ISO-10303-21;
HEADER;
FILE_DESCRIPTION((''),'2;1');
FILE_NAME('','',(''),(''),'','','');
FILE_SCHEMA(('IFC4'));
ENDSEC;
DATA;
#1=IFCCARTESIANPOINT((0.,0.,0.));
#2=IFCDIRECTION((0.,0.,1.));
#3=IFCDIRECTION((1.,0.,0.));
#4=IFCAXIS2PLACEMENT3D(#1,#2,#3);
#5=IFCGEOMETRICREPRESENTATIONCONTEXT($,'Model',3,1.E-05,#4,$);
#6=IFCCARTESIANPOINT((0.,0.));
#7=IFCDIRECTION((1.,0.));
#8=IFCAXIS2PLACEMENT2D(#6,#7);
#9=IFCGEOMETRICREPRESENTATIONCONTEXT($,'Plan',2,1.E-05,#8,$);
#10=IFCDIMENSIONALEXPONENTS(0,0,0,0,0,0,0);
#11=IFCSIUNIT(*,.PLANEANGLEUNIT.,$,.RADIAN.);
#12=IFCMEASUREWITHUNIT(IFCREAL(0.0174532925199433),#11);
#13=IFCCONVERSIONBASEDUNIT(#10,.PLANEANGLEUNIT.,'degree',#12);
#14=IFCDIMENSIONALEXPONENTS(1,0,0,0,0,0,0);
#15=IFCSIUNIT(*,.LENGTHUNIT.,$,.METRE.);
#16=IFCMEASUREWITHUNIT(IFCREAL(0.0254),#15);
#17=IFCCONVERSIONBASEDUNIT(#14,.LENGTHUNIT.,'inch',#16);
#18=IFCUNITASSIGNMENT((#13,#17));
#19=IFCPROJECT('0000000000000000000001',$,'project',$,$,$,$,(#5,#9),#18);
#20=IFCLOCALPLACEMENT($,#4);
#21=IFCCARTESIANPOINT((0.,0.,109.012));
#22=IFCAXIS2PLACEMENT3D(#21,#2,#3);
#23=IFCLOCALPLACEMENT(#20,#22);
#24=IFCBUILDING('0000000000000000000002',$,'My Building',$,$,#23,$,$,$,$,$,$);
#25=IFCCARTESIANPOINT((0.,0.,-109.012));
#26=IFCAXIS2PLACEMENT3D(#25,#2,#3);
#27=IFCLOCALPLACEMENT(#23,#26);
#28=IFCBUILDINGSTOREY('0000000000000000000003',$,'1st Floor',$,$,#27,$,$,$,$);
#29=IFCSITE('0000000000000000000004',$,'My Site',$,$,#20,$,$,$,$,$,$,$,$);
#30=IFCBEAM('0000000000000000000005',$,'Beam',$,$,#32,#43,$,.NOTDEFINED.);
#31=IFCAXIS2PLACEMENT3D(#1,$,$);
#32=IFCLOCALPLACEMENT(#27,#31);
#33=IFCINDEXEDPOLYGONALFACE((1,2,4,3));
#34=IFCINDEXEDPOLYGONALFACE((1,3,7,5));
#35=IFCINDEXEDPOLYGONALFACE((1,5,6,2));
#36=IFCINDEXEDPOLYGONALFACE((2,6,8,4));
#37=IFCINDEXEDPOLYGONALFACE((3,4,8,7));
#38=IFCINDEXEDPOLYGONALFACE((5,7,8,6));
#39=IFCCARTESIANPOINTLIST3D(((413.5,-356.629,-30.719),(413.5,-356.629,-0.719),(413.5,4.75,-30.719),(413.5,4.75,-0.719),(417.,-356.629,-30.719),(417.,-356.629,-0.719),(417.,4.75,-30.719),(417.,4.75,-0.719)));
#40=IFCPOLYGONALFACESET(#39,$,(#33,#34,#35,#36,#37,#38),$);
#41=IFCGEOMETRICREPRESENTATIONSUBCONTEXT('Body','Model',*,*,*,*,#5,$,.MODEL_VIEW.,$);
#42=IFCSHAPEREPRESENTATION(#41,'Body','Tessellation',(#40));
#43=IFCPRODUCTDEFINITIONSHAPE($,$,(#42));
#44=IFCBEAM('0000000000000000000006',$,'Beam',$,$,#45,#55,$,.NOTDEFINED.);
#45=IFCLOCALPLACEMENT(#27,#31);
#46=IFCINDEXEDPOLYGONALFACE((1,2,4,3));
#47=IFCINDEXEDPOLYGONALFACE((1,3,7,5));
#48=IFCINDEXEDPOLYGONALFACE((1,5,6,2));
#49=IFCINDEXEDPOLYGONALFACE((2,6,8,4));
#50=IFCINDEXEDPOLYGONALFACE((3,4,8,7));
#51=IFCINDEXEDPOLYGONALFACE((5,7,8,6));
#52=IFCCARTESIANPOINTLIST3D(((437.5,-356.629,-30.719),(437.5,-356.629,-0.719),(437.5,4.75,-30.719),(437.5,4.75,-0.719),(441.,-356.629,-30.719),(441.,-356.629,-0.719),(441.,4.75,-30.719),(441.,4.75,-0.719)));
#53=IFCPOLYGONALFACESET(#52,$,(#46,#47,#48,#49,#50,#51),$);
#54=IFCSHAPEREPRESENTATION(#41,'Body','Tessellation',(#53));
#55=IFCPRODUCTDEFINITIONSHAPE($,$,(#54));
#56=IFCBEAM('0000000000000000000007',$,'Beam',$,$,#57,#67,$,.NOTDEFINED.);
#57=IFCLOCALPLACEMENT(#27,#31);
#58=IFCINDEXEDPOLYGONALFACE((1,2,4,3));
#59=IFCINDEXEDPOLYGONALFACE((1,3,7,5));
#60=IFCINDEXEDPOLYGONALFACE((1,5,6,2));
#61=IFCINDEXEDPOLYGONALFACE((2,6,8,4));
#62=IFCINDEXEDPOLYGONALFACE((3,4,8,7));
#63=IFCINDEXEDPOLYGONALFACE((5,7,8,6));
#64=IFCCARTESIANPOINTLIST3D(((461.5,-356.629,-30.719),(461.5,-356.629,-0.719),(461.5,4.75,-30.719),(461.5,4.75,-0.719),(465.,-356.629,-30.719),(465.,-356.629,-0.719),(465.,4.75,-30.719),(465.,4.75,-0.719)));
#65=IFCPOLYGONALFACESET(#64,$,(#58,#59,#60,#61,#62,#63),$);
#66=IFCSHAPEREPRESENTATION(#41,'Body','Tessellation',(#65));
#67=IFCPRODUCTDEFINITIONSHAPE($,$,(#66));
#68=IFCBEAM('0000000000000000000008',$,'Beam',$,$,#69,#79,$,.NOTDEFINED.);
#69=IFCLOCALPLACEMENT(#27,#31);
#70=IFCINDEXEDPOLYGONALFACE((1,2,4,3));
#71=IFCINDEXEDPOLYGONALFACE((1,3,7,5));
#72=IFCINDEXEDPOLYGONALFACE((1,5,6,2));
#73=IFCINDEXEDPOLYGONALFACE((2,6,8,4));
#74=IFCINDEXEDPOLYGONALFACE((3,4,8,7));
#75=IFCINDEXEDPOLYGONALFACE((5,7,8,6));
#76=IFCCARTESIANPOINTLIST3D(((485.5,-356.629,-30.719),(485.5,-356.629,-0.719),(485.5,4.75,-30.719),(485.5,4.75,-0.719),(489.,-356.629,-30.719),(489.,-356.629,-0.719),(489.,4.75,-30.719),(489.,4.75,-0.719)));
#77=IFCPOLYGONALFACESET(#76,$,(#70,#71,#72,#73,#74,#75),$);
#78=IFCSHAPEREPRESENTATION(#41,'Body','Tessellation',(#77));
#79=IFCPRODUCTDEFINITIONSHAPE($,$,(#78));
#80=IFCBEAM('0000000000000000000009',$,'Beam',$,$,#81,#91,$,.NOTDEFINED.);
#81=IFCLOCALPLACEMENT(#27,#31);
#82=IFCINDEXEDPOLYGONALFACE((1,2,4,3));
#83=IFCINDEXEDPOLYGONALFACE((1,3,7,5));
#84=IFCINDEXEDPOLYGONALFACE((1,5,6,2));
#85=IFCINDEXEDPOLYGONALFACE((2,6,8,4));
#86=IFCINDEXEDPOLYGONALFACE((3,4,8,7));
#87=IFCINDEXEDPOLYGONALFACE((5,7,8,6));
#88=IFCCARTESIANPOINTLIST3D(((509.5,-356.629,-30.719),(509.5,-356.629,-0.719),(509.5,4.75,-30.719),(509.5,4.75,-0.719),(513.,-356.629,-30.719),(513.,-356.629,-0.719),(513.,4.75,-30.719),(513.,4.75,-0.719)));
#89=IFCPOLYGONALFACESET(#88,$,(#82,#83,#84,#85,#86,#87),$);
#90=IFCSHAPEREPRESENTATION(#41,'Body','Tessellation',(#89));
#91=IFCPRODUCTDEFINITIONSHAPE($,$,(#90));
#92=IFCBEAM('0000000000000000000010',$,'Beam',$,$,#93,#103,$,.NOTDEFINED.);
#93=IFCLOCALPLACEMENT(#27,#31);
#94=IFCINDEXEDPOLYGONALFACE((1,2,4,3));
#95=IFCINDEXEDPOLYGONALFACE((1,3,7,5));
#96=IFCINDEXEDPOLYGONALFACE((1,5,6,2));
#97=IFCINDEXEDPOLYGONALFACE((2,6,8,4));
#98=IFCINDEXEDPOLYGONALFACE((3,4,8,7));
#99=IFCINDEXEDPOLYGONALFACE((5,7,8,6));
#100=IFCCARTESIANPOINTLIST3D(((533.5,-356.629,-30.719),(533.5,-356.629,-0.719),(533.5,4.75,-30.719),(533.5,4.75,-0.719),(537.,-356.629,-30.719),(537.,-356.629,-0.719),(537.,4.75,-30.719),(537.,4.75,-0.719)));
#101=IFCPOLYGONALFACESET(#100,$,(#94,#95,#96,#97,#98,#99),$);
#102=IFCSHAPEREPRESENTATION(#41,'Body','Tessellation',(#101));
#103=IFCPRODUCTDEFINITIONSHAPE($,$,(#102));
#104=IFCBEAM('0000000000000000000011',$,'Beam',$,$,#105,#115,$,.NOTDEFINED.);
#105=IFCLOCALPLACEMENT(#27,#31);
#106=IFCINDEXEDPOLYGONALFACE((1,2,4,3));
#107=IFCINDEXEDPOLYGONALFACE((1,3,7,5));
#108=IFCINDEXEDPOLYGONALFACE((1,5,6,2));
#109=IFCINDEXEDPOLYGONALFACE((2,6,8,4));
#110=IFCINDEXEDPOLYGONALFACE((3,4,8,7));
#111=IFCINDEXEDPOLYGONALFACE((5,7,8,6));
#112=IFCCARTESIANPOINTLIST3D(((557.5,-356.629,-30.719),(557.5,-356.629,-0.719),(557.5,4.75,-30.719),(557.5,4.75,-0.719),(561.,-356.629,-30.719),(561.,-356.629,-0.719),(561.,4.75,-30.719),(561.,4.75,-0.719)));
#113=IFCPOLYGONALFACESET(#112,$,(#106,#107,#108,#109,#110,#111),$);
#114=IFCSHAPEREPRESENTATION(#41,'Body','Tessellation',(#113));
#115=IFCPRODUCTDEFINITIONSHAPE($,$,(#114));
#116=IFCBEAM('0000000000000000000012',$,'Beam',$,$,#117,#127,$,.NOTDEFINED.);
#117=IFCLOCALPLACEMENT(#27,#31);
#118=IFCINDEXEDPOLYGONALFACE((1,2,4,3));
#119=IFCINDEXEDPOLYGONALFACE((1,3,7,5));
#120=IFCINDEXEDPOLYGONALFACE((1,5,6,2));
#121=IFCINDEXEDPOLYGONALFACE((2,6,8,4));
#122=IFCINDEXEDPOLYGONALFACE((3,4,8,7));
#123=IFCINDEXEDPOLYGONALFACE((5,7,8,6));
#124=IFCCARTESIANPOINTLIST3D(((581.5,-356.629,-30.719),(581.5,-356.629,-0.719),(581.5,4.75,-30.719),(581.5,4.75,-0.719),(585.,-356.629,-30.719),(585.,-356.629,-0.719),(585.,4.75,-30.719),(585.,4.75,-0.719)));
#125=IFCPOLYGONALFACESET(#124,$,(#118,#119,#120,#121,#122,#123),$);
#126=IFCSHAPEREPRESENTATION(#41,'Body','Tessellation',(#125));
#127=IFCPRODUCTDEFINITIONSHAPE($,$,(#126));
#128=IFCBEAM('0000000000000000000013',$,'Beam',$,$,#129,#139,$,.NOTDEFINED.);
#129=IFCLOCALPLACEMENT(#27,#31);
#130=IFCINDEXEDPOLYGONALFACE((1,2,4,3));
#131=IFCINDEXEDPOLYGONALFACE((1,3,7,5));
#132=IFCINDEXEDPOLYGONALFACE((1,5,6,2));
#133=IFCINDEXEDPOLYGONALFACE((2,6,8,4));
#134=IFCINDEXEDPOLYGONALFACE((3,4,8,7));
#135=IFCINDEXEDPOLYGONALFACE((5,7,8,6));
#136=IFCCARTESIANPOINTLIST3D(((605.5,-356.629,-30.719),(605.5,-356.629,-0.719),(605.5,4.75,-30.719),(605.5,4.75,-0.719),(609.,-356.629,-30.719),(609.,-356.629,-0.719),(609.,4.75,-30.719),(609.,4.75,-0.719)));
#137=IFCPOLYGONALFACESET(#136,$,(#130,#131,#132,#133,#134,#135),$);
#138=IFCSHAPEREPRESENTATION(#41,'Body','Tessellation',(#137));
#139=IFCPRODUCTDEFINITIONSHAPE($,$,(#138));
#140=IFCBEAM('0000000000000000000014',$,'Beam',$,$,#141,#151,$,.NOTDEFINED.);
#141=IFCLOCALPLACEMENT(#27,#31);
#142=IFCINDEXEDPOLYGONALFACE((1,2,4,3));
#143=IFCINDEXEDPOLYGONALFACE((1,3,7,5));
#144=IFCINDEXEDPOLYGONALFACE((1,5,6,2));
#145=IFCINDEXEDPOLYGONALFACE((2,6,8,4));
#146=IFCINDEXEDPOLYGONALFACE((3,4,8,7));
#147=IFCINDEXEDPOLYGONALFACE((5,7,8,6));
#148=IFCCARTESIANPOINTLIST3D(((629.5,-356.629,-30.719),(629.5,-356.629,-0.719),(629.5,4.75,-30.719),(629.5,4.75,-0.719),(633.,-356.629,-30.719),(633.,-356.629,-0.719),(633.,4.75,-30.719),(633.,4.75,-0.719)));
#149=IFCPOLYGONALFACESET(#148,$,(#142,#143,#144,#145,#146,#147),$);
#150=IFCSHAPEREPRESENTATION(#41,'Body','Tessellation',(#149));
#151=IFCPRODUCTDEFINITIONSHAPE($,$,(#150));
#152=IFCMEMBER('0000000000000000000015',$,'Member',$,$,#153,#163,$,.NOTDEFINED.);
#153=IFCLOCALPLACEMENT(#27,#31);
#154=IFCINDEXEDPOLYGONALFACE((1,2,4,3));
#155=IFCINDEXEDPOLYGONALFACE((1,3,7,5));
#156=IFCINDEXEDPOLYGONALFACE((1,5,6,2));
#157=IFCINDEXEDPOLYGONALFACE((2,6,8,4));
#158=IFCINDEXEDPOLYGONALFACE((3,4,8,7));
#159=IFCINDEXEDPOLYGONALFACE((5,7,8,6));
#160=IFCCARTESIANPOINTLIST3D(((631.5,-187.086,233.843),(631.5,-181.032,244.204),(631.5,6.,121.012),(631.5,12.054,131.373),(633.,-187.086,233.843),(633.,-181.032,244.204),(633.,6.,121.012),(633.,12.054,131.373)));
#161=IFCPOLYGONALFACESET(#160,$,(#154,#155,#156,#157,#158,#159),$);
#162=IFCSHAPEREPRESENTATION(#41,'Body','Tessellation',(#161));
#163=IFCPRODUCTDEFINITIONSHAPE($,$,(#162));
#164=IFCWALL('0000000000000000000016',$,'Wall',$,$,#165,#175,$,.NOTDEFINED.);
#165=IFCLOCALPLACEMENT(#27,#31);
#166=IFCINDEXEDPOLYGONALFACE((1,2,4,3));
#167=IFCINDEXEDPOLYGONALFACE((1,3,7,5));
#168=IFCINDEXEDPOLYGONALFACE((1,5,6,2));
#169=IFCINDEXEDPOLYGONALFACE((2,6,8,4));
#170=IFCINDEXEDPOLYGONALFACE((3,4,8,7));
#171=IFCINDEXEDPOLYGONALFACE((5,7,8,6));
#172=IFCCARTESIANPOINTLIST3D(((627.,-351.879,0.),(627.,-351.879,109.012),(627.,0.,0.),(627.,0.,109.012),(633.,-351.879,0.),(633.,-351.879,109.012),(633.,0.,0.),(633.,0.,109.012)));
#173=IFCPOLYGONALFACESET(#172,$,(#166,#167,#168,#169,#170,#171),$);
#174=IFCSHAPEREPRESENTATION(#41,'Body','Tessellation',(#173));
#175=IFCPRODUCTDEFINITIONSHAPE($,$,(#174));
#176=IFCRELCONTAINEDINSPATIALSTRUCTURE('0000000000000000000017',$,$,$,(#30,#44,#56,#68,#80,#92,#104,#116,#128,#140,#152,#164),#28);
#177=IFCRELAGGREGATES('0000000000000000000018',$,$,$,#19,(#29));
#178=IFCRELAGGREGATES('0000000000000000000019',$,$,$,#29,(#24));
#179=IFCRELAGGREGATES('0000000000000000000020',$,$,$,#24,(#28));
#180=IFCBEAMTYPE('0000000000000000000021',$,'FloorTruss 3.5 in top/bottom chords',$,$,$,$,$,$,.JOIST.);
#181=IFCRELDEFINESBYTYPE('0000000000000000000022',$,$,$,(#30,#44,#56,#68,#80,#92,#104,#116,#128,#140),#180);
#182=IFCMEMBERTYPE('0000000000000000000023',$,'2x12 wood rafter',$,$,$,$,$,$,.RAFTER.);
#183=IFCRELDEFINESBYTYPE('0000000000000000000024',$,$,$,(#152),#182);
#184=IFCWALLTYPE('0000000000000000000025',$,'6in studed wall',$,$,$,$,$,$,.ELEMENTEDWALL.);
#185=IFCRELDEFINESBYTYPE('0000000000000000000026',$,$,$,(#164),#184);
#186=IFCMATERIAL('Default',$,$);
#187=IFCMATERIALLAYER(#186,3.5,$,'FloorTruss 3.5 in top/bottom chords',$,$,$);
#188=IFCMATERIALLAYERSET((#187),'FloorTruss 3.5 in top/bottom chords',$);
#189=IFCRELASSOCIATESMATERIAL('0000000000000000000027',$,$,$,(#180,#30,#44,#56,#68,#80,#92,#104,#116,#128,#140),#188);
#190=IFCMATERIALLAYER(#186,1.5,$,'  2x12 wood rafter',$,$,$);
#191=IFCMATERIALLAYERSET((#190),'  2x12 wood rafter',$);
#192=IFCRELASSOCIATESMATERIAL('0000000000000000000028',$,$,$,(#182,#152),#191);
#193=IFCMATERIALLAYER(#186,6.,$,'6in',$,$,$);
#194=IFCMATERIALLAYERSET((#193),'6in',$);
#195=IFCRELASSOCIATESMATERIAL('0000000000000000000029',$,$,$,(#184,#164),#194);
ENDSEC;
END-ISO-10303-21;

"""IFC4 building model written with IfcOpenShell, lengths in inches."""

from ifc_helpers import new_model, entity, si_unit, converted_unit, frame, origin_with_axes, origin_2d_with_axis, place, context, subcontext, project, spatial, indexed_curve, outline, extrude, material, layer, layer_set, layer_usage, type_object, element, save


model = new_model("IFC4")

# Units and contexts
model_context = context("Model", 3, precision=1e-05, world=origin_with_axes())
plan_context = context("Plan", 2, precision=1e-05, world=origin_2d_with_axis())
body_context = subcontext(model_context, "Body", "Model", "MODEL_VIEW")
ifc_project = project(units=[converted_unit("PLANEANGLEUNIT", "degree", entity("IfcReal", 0.0174532925199433), si_unit("PLANEANGLEUNIT", "RADIAN"), dimensions=[0, 0, 0, 0, 0, 0, 0]), converted_unit("LENGTHUNIT", "inch", entity("IfcReal", 0.0254), si_unit("LENGTHUNIT", "METRE"), dimensions=[1, 0, 0, 0, 0, 0, 0])], contexts=[model_context, plan_context])

# Site, building, storey
site_placement = place(None, origin_with_axes())
site = spatial("IfcSite", under=ifc_project, at=site_placement, Name="My Site")
building_placement = place(site_placement, frame((0.0, 0.0, 109.012), z_axis=(0.0, 0.0, 1.0), x_axis=(1.0, 0.0, 0.0)))
building = spatial("IfcBuilding", under=site, at=building_placement, Name="My Building")
storey_placement = place(building_placement, frame((0.0, 0.0, -109.012), z_axis=(0.0, 0.0, 1.0), x_axis=(1.0, 0.0, 0.0)))
storey = spatial("IfcBuildingStorey", under=building, at=storey_placement, Name="1st Floor")

# Beams
ifc_material = material(Name="Default")
ifc_layer_1 = layer(ifc_material, 3.5, Name="FloorTruss 3.5 in top/bottom chords")
ifc_layer_set_1 = layer_set([ifc_layer_1], Name="FloorTruss 3.5 in top/bottom chords")
ifc_layer_usage_1 = layer_usage(ifc_layer_set_1, "AXIS2", "POSITIVE", 0.0)
beam_type = type_object("IfcBeamType", Name="FloorTruss 3.5 in top/bottom chords", PredefinedType="JOIST", material=ifc_layer_set_1)
beam_1_placement = place(storey_placement, frame((417.0, -356.629, -30.719), z_axis=(0.0, 0.0, 1.0), x_axis=(0.0, 1.0, 0.0)))
element("IfcBeam", 1, at=beam_1_placement, inside=storey, type_object=beam_type, material=ifc_layer_usage_1, Name="Beam", PredefinedType="NOTDEFINED", context=body_context, shape_type="SweptSolid", body=[
    extrude(outline(indexed_curve([(0.0, 0.0), (0.0, 3.5), (361.379, 3.5), (361.379, 0.0), (0.0, 0.0)], self_intersect=False)), origin_with_axes(), (0.0, 0.0, 1.0), 30.0),
])
ifc_layer_usage_2 = layer_usage(ifc_layer_set_1, "AXIS2", "POSITIVE", 0.0)
beam_2_placement = place(storey_placement, frame((441.0, -356.629, -30.719), z_axis=(0.0, 0.0, 1.0), x_axis=(0.0, 1.0, 0.0)))
element("IfcBeam", 2, at=beam_2_placement, inside=storey, type_object=beam_type, material=ifc_layer_usage_2, Name="Beam", PredefinedType="NOTDEFINED", context=body_context, shape_type="SweptSolid", body=[
    extrude(outline(indexed_curve([(0.0, 0.0), (0.0, 3.5), (361.379, 3.5), (361.379, 0.0), (0.0, 0.0)], self_intersect=False)), origin_with_axes(), (0.0, 0.0, 1.0), 30.0),
])
ifc_layer_usage_3 = layer_usage(ifc_layer_set_1, "AXIS2", "POSITIVE", 0.0)
beam_3_placement = place(storey_placement, frame((465.0, -356.629, -30.719), z_axis=(0.0, 0.0, 1.0), x_axis=(0.0, 1.0, 0.0)))
element("IfcBeam", 3, at=beam_3_placement, inside=storey, type_object=beam_type, material=ifc_layer_usage_3, Name="Beam", PredefinedType="NOTDEFINED", context=body_context, shape_type="SweptSolid", body=[
    extrude(outline(indexed_curve([(0.0, 0.0), (0.0, 3.5), (361.379, 3.5), (361.379, 0.0), (0.0, 0.0)], self_intersect=False)), origin_with_axes(), (0.0, 0.0, 1.0), 30.0),
])
ifc_layer_usage_4 = layer_usage(ifc_layer_set_1, "AXIS2", "POSITIVE", 0.0)
beam_4_placement = place(storey_placement, frame((489.0, -356.629, -30.719), z_axis=(0.0, 0.0, 1.0), x_axis=(0.0, 1.0, 0.0)))
element("IfcBeam", 4, at=beam_4_placement, inside=storey, type_object=beam_type, material=ifc_layer_usage_4, Name="Beam", PredefinedType="NOTDEFINED", context=body_context, shape_type="SweptSolid", body=[
    extrude(outline(indexed_curve([(0.0, 0.0), (0.0, 3.5), (361.379, 3.5), (361.379, 0.0), (0.0, 0.0)], self_intersect=False)), origin_with_axes(), (0.0, 0.0, 1.0), 30.0),
])
ifc_layer_usage_5 = layer_usage(ifc_layer_set_1, "AXIS2", "POSITIVE", 0.0)
beam_5_placement = place(storey_placement, frame((513.0, -356.629, -30.719), z_axis=(0.0, 0.0, 1.0), x_axis=(0.0, 1.0, 0.0)))
element("IfcBeam", 5, at=beam_5_placement, inside=storey, type_object=beam_type, material=ifc_layer_usage_5, Name="Beam", PredefinedType="NOTDEFINED", context=body_context, shape_type="SweptSolid", body=[
    extrude(outline(indexed_curve([(0.0, 0.0), (0.0, 3.5), (361.379, 3.5), (361.379, 0.0), (0.0, 0.0)], self_intersect=False)), origin_with_axes(), (0.0, 0.0, 1.0), 30.0),
])
ifc_layer_usage_6 = layer_usage(ifc_layer_set_1, "AXIS2", "POSITIVE", 0.0)
beam_6_placement = place(storey_placement, frame((537.0, -356.629, -30.719), z_axis=(0.0, 0.0, 1.0), x_axis=(0.0, 1.0, 0.0)))
element("IfcBeam", 6, at=beam_6_placement, inside=storey, type_object=beam_type, material=ifc_layer_usage_6, Name="Beam", PredefinedType="NOTDEFINED", context=body_context, shape_type="SweptSolid", body=[
    extrude(outline(indexed_curve([(0.0, 0.0), (0.0, 3.5), (361.379, 3.5), (361.379, 0.0), (0.0, 0.0)], self_intersect=False)), origin_with_axes(), (0.0, 0.0, 1.0), 30.0),
])
ifc_layer_usage_7 = layer_usage(ifc_layer_set_1, "AXIS2", "POSITIVE", 0.0)
beam_7_placement = place(storey_placement, frame((561.0, -356.629, -30.719), z_axis=(0.0, 0.0, 1.0), x_axis=(0.0, 1.0, 0.0)))
element("IfcBeam", 7, at=beam_7_placement, inside=storey, type_object=beam_type, material=ifc_layer_usage_7, Name="Beam", PredefinedType="NOTDEFINED", context=body_context, shape_type="SweptSolid", body=[
    extrude(outline(indexed_curve([(0.0, 0.0), (0.0, 3.5), (361.379, 3.5), (361.379, 0.0), (0.0, 0.0)], self_intersect=False)), origin_with_axes(), (0.0, 0.0, 1.0), 30.0),
])
ifc_layer_usage_8 = layer_usage(ifc_layer_set_1, "AXIS2", "POSITIVE", 0.0)
beam_8_placement = place(storey_placement, frame((585.0, -356.629, -30.719), z_axis=(0.0, 0.0, 1.0), x_axis=(0.0, 1.0, 0.0)))
element("IfcBeam", 8, at=beam_8_placement, inside=storey, type_object=beam_type, material=ifc_layer_usage_8, Name="Beam", PredefinedType="NOTDEFINED", context=body_context, shape_type="SweptSolid", body=[
    extrude(outline(indexed_curve([(0.0, 0.0), (0.0, 3.5), (361.379, 3.5), (361.379, 0.0), (0.0, 0.0)], self_intersect=False)), origin_with_axes(), (0.0, 0.0, 1.0), 30.0),
])
ifc_layer_usage_9 = layer_usage(ifc_layer_set_1, "AXIS2", "POSITIVE", 0.0)
beam_9_placement = place(storey_placement, frame((609.0, -356.629, -30.719), z_axis=(0.0, 0.0, 1.0), x_axis=(0.0, 1.0, 0.0)))
element("IfcBeam", 9, at=beam_9_placement, inside=storey, type_object=beam_type, material=ifc_layer_usage_9, Name="Beam", PredefinedType="NOTDEFINED", context=body_context, shape_type="SweptSolid", body=[
    extrude(outline(indexed_curve([(0.0, 0.0), (0.0, 3.5), (361.379, 3.5), (361.379, 0.0), (0.0, 0.0)], self_intersect=False)), origin_with_axes(), (0.0, 0.0, 1.0), 30.0),
])
ifc_layer_usage_10 = layer_usage(ifc_layer_set_1, "AXIS2", "POSITIVE", 0.0)
beam_10_placement = place(storey_placement, frame((633.0, -356.629, -30.719), z_axis=(0.0, 0.0, 1.0), x_axis=(0.0, 1.0, 0.0)))
element("IfcBeam", 10, at=beam_10_placement, inside=storey, type_object=beam_type, material=ifc_layer_usage_10, Name="Beam", PredefinedType="NOTDEFINED", context=body_context, shape_type="SweptSolid", body=[
    extrude(outline(indexed_curve([(0.0, 0.0), (0.0, 3.5), (361.379, 3.5), (361.379, 0.0), (0.0, 0.0)], self_intersect=False)), origin_with_axes(), (0.0, 0.0, 1.0), 30.0),
])

# Member
ifc_layer_2 = layer(ifc_material, 1.5, Name="  2x12 wood rafter")
ifc_layer_set_2 = layer_set([ifc_layer_2], Name="  2x12 wood rafter")
ifc_layer_usage_11 = layer_usage(ifc_layer_set_2, "AXIS2", "POSITIVE", 0.0)
member_type = type_object("IfcMemberType", Name="2x12 wood rafter", PredefinedType="RAFTER", material=ifc_layer_set_2)
member_1_placement = place(storey_placement, frame((631.5, 6.0, 121.012), z_axis=(0.0, 0.504528, 0.863396), x_axis=(-0.000001, -0.863396, 0.504528)))
element("IfcMember", 11, at=member_1_placement, inside=storey, type_object=member_type, material=ifc_layer_usage_11, Name="Member", PredefinedType="NOTDEFINED", context=body_context, shape_type="SweptSolid", body=[
    extrude(outline(indexed_curve([(0.0, 0.0), (0.0, 1.5), (223.636, 1.5), (223.636, 0.0), (0.0, 0.0)], self_intersect=False)), origin_with_axes(), (0.0, 0.0, 1.0), 12.0),
])

# Wall
ifc_layer_3 = layer(ifc_material, 6.0, Name="6in")
ifc_layer_set_3 = layer_set([ifc_layer_3], Name="6in")
ifc_layer_usage_12 = layer_usage(ifc_layer_set_3, "AXIS2", "POSITIVE", 0.0)
wall_type_1 = type_object("IfcWallType", Name="6in studed wall", PredefinedType="ELEMENTEDWALL", material=ifc_layer_set_3)
wall_1_placement = place(storey_placement, frame((633.0, -351.879, 0.0), z_axis=(0.0, 0.0, 1.0), x_axis=(0.000001, 1.0, 0.0)))
element("IfcWall", 12, at=wall_1_placement, inside=storey, type_object=wall_type_1, material=ifc_layer_usage_12, Name="Wall", PredefinedType="NOTDEFINED", context=body_context, shape_type="SweptSolid", body=[
    extrude(outline(indexed_curve([(0.0, 0.0), (0.0, 6.0), (351.879, 6.0), (351.879, 0.0), (0.0, 0.0)], self_intersect=False)), origin_with_axes(), (0.0, 0.0, 1.0), 109.012),
])

save(model, "model.ifc")
